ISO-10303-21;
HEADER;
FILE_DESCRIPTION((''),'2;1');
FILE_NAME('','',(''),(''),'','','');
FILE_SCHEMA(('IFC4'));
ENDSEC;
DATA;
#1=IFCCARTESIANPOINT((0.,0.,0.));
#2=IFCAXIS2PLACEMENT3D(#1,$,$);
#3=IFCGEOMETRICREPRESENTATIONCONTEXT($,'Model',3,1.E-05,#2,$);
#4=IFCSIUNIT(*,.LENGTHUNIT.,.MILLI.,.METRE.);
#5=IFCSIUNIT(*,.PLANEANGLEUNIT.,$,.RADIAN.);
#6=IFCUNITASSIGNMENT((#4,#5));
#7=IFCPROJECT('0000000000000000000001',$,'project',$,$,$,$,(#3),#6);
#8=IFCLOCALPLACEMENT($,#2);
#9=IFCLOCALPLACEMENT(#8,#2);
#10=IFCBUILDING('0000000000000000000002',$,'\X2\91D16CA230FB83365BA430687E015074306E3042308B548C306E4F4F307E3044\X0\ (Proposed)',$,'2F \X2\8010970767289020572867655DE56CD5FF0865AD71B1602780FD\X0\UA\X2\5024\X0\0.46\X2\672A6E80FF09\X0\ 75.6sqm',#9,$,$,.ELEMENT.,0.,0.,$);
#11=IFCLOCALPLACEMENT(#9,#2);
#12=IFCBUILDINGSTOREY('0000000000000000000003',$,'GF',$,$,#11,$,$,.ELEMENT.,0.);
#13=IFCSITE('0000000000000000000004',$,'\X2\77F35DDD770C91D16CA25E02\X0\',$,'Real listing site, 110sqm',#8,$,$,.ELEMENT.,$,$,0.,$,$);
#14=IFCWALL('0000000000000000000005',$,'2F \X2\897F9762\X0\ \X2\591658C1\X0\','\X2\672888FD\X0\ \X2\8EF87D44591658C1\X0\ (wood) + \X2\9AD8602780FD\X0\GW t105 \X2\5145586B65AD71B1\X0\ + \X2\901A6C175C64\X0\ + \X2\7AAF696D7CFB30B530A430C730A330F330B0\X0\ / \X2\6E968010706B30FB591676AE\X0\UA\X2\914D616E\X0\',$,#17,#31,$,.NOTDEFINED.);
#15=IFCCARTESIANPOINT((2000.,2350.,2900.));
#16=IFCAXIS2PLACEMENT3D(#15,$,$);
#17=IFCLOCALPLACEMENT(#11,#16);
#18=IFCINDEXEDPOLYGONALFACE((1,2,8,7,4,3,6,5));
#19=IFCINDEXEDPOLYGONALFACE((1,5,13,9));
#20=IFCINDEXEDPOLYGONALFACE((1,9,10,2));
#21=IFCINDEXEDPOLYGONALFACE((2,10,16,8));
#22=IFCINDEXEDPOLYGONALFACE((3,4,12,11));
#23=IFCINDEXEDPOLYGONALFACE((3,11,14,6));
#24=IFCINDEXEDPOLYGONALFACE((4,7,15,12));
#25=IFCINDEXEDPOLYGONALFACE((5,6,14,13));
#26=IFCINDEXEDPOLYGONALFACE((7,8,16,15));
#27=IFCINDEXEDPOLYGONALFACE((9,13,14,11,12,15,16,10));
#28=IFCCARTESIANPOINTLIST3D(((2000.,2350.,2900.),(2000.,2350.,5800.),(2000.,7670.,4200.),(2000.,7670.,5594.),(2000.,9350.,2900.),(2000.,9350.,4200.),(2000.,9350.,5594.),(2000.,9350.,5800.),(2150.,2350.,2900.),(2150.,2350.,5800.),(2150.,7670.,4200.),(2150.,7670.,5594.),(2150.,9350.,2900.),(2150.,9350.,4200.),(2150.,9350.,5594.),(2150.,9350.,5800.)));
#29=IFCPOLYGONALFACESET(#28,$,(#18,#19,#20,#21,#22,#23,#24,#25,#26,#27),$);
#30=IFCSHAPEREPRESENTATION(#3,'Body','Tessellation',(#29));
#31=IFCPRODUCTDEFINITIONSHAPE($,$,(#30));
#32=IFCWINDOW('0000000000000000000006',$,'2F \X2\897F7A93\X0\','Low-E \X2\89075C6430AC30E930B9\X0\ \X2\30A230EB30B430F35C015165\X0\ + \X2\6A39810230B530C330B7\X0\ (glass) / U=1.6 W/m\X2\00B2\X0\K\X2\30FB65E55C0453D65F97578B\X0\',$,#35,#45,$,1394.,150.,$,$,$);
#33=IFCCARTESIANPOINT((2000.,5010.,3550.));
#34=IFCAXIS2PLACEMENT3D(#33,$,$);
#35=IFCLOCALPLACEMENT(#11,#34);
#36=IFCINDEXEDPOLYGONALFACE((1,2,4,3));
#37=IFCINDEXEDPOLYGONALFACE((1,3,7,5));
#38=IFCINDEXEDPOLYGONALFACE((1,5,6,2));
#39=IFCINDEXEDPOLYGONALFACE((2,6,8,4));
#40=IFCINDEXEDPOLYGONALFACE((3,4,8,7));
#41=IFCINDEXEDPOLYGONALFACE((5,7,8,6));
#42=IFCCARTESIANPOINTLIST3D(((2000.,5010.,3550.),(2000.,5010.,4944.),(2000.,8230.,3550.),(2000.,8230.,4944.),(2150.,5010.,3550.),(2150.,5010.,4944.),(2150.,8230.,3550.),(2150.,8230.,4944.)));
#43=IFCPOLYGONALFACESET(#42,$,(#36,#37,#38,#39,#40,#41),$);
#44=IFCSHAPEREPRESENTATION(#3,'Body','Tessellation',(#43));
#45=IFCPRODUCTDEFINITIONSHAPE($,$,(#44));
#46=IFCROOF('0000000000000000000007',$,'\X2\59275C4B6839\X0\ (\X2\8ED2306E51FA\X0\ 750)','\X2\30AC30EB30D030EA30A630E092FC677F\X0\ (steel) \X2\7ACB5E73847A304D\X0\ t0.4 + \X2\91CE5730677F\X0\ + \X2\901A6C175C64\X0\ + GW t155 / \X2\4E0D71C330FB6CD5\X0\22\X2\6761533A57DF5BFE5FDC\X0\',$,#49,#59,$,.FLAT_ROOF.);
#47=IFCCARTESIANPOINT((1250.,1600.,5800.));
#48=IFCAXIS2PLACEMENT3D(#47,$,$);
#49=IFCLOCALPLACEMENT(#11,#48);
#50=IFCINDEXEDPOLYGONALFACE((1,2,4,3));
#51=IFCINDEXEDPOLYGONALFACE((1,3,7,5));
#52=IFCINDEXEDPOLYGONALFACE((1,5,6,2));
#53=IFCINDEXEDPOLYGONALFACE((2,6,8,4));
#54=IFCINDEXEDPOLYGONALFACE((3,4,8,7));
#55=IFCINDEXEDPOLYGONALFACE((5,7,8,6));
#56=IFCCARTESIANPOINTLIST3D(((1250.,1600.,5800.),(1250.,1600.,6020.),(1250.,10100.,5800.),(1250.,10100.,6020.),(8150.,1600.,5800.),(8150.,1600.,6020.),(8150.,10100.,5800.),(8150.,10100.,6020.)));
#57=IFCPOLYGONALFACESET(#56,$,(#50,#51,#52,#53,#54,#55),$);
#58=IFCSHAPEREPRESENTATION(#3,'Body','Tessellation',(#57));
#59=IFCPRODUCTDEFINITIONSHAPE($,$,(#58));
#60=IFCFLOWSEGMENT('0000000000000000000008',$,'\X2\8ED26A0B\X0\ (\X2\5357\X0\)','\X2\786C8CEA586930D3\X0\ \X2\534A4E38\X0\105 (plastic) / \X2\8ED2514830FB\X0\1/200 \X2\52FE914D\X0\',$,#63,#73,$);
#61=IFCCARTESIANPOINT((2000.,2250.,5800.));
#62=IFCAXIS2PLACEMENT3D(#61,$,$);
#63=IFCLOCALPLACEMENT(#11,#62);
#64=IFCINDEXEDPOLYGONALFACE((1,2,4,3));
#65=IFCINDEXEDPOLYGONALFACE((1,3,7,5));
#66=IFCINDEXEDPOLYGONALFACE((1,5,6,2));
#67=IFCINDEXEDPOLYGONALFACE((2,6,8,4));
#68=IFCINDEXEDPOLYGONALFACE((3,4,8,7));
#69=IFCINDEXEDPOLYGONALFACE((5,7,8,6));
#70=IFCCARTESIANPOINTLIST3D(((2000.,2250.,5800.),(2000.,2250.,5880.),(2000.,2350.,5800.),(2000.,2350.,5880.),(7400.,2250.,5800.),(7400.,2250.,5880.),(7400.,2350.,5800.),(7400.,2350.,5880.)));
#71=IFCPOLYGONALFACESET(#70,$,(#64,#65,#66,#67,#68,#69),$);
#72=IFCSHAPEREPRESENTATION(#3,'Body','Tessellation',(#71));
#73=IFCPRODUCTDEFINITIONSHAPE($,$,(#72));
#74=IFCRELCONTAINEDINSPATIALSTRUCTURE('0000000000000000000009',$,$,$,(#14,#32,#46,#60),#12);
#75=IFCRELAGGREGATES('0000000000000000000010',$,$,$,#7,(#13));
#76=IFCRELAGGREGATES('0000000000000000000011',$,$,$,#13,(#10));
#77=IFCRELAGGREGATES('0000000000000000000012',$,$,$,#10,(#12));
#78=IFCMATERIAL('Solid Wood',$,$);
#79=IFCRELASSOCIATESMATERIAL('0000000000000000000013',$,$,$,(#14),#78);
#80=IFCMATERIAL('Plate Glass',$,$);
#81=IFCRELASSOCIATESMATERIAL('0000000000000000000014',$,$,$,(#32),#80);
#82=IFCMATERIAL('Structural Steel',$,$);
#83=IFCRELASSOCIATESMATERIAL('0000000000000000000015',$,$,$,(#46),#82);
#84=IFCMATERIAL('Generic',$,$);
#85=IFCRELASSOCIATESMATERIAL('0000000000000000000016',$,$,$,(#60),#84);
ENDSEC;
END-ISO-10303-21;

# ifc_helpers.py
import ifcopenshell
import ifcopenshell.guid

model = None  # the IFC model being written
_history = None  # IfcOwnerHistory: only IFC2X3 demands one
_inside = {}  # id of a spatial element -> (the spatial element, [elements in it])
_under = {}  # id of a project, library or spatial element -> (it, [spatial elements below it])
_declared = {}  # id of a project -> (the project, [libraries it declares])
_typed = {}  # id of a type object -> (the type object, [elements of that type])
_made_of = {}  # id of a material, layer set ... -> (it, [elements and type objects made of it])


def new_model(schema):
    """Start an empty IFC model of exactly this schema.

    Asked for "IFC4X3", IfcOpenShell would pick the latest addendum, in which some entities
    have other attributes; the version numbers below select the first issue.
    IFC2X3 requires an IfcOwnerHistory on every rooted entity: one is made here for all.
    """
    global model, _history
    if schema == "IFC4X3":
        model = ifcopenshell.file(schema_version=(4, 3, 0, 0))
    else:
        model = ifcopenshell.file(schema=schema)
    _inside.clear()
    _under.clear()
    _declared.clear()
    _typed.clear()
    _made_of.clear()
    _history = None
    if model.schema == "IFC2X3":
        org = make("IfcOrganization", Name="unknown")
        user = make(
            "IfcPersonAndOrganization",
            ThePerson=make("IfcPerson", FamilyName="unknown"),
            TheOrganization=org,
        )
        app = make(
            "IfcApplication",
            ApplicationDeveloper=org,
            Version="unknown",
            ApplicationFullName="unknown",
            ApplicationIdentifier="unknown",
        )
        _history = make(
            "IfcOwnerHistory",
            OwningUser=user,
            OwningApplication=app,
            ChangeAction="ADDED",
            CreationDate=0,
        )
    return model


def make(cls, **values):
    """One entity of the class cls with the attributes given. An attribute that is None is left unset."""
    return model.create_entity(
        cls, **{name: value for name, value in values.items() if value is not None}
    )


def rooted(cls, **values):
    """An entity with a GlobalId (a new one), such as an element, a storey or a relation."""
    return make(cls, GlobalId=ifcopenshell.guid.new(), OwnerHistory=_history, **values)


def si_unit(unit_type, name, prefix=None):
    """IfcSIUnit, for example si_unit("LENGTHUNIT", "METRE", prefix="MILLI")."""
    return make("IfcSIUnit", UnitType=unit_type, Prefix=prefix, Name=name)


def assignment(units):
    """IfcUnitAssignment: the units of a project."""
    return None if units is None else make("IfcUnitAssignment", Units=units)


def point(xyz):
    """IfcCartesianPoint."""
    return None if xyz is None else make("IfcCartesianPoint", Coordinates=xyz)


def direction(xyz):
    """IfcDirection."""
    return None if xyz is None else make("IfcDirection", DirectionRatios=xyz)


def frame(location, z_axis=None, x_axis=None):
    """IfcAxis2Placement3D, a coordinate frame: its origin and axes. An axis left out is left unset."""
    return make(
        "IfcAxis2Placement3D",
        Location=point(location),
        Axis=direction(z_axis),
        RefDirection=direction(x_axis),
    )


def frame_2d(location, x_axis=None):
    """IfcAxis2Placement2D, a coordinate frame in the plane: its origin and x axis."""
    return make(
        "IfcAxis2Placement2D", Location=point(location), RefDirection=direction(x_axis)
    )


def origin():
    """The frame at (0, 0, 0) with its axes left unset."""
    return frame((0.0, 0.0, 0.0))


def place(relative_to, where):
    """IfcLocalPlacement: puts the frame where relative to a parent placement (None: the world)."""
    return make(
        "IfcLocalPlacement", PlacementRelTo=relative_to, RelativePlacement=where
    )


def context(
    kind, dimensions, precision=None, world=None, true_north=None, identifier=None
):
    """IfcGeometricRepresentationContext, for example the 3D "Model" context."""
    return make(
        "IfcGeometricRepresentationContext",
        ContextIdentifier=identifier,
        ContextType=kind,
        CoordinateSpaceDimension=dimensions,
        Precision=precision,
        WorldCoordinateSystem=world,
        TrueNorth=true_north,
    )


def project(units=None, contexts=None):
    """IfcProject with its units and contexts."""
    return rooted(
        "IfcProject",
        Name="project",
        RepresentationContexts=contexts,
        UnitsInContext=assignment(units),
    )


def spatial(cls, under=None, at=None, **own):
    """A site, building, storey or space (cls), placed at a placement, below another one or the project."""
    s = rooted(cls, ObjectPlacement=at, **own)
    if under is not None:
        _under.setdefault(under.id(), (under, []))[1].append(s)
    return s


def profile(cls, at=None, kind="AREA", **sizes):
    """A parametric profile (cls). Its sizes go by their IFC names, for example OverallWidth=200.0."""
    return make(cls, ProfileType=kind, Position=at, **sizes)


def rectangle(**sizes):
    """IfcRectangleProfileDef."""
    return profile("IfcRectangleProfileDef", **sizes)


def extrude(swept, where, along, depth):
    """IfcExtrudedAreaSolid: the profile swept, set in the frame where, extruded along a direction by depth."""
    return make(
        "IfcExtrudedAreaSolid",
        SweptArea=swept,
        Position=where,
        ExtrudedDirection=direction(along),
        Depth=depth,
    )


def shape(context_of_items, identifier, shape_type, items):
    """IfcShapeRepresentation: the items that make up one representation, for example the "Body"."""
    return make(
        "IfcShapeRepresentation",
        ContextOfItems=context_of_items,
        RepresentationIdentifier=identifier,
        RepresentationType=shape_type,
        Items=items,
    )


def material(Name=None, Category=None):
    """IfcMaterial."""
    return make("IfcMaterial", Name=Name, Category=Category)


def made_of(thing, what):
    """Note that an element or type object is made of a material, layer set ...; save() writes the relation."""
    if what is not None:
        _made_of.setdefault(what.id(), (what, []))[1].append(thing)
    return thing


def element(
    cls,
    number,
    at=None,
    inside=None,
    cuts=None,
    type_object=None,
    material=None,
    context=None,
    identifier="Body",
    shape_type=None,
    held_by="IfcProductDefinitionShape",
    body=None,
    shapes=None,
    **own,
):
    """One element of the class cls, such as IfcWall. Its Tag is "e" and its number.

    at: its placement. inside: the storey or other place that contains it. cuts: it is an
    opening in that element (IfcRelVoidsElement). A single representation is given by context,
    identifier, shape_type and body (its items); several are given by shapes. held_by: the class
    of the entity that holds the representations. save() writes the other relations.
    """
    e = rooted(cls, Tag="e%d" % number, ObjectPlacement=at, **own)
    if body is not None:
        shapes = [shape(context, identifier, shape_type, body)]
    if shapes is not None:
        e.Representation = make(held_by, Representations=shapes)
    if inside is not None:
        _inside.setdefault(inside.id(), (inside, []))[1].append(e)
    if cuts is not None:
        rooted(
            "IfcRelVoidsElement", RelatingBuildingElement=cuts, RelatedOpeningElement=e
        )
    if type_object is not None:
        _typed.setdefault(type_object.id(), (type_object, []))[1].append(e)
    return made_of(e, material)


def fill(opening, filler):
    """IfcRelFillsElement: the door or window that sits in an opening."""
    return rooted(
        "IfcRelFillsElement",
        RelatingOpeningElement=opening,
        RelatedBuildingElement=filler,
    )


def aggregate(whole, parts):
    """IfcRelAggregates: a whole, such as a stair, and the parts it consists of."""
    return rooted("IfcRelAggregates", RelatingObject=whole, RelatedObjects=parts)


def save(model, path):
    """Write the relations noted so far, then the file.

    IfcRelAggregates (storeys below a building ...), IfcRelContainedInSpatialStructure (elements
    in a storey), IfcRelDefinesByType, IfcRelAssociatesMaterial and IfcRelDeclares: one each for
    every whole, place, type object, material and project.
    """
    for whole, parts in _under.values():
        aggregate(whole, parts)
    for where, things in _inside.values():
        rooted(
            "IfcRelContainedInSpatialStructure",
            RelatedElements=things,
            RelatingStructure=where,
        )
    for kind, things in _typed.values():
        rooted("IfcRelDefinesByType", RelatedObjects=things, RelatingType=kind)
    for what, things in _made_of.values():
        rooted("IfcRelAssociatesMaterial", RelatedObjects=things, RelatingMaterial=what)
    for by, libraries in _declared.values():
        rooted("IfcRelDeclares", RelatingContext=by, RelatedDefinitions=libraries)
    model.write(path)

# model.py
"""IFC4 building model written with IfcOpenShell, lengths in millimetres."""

from ifc_helpers import new_model, si_unit, frame, frame_2d, origin, place, context, project, spatial, rectangle, extrude, material, element, fill, save


model = new_model("IFC4")

# Units and contexts
model_context = context("Model", 3, precision=1e-05, world=origin())
ifc_project = project(units=[si_unit("LENGTHUNIT", "METRE", prefix="MILLI"), si_unit("PLANEANGLEUNIT", "RADIAN")], contexts=[model_context])

# Site, building, storey
site_placement = place(None, origin())
site = spatial("IfcSite", under=ifc_project, at=site_placement, Name="石川県金沢市", ObjectType="Real listing site, 110sqm", CompositionType="ELEMENT", RefElevation=0.0)
building_placement = place(site_placement, origin())
building = spatial("IfcBuilding", under=site, at=building_placement, Name="金沢・茶室と縁側のある和の住まい (Proposed)", ObjectType="2F 耐震木造在来工法（断熱性能UA値0.46未満） 75.6sqm", CompositionType="ELEMENT", ElevationOfRefHeight=0.0, ElevationOfTerrain=0.0)
storey_placement = place(building_placement, origin())
storey = spatial("IfcBuildingStorey", under=building, at=storey_placement, Name="GF", CompositionType="ELEMENT", Elevation=0.0)

# Shared definitions
ifc_material_1 = material(Name="Solid Wood")

# Shared definitions
ifc_material_2 = material(Name="Plate Glass")

# Wall, opening, window
wall_1_placement = place(storey_placement, frame((2000.0, 2350.0, 2900.0)))
wall_1 = element("IfcWall", 1, at=wall_1_placement, inside=storey, material=ifc_material_1, Name="2F 西面 外壁", Description="木製 軸組外壁 (wood) + 高性能GW t105 充填断熱 + 通気層 + 窯業系サイディング / 準耐火・外皮UA配慮", PredefinedType="NOTDEFINED", context=model_context, shape_type="SweptSolid", body=[
    extrude(rectangle(XDim=150.0, YDim=7000.0, at=frame_2d((75.0, 3500.0))), frame((2000.0, 2350.0, 2900.0)), (0.0, 0.0, 1.0), 2900.0),
])
opening_1_placement = place(storey_placement, frame((2000.0, 5010.0, 3550.0)))
opening_1 = element("IfcOpeningElement", 2, at=opening_1_placement, cuts=wall_1, PredefinedType="NOTDEFINED", context=model_context, shape_type="SweptSolid", body=[
    extrude(rectangle(XDim=150.0, YDim=3220.0, at=frame_2d((75.0, 1610.0))), frame((2000.0, 5010.0, 3550.0)), (0.0, 0.0, 1.0), 1394.0),
])
window_1_placement = place(storey_placement, frame((2000.0, 5010.0, 3550.0)))
window_1 = element("IfcWindow", 3, at=window_1_placement, inside=storey, material=ifc_material_2, Name="2F 西窓", Description="Low-E 複層ガラス アルゴン封入 + 樹脂サッシ (glass) / U=1.6 W/m²K・日射取得型", OverallHeight=1394.0, OverallWidth=150.0, context=model_context, shape_type="SweptSolid", body=[
    extrude(rectangle(XDim=150.0, YDim=3220.0, at=frame_2d((75.0, 1610.0))), frame((2000.0, 5010.0, 3550.0)), (0.0, 0.0, 1.0), 1394.0),
])
fill(opening_1, window_1)

# Roof
ifc_material_3 = material(Name="Structural Steel")
roof_placement = place(storey_placement, frame((1250.0, 1600.0, 5800.0)))
element("IfcRoof", 4, at=roof_placement, inside=storey, material=ifc_material_3, Name="大屋根 (軒の出 750)", Description="ガルバリウム鋼板 (steel) 立平葺き t0.4 + 野地板 + 通気層 + GW t155 / 不燃・法22条区域対応", PredefinedType="FLAT_ROOF", context=model_context, shape_type="SweptSolid", body=[
    extrude(rectangle(XDim=6900.0, YDim=8500.0, at=frame_2d((3450.0, 4250.0))), frame((1250.0, 1600.0, 5800.0)), (0.0, 0.0, 1.0), 220.0),
])

# Flow segment
ifc_material_4 = material(Name="Generic")
flow_segment_placement = place(storey_placement, frame((2000.0, 2250.0, 5800.0)))
element("IfcFlowSegment", 5, at=flow_segment_placement, inside=storey, material=ifc_material_4, Name="軒樋 (南)", Description="硬質塩ビ 半丸105 (plastic) / 軒先・1/200 勾配", context=model_context, shape_type="SweptSolid", body=[
    extrude(rectangle(XDim=5400.0, YDim=100.0, at=frame_2d((2700.0, 50.0))), frame((2000.0, 2250.0, 5800.0)), (0.0, 0.0, 1.0), 80.0),
])

save(model, "model.ifc")
